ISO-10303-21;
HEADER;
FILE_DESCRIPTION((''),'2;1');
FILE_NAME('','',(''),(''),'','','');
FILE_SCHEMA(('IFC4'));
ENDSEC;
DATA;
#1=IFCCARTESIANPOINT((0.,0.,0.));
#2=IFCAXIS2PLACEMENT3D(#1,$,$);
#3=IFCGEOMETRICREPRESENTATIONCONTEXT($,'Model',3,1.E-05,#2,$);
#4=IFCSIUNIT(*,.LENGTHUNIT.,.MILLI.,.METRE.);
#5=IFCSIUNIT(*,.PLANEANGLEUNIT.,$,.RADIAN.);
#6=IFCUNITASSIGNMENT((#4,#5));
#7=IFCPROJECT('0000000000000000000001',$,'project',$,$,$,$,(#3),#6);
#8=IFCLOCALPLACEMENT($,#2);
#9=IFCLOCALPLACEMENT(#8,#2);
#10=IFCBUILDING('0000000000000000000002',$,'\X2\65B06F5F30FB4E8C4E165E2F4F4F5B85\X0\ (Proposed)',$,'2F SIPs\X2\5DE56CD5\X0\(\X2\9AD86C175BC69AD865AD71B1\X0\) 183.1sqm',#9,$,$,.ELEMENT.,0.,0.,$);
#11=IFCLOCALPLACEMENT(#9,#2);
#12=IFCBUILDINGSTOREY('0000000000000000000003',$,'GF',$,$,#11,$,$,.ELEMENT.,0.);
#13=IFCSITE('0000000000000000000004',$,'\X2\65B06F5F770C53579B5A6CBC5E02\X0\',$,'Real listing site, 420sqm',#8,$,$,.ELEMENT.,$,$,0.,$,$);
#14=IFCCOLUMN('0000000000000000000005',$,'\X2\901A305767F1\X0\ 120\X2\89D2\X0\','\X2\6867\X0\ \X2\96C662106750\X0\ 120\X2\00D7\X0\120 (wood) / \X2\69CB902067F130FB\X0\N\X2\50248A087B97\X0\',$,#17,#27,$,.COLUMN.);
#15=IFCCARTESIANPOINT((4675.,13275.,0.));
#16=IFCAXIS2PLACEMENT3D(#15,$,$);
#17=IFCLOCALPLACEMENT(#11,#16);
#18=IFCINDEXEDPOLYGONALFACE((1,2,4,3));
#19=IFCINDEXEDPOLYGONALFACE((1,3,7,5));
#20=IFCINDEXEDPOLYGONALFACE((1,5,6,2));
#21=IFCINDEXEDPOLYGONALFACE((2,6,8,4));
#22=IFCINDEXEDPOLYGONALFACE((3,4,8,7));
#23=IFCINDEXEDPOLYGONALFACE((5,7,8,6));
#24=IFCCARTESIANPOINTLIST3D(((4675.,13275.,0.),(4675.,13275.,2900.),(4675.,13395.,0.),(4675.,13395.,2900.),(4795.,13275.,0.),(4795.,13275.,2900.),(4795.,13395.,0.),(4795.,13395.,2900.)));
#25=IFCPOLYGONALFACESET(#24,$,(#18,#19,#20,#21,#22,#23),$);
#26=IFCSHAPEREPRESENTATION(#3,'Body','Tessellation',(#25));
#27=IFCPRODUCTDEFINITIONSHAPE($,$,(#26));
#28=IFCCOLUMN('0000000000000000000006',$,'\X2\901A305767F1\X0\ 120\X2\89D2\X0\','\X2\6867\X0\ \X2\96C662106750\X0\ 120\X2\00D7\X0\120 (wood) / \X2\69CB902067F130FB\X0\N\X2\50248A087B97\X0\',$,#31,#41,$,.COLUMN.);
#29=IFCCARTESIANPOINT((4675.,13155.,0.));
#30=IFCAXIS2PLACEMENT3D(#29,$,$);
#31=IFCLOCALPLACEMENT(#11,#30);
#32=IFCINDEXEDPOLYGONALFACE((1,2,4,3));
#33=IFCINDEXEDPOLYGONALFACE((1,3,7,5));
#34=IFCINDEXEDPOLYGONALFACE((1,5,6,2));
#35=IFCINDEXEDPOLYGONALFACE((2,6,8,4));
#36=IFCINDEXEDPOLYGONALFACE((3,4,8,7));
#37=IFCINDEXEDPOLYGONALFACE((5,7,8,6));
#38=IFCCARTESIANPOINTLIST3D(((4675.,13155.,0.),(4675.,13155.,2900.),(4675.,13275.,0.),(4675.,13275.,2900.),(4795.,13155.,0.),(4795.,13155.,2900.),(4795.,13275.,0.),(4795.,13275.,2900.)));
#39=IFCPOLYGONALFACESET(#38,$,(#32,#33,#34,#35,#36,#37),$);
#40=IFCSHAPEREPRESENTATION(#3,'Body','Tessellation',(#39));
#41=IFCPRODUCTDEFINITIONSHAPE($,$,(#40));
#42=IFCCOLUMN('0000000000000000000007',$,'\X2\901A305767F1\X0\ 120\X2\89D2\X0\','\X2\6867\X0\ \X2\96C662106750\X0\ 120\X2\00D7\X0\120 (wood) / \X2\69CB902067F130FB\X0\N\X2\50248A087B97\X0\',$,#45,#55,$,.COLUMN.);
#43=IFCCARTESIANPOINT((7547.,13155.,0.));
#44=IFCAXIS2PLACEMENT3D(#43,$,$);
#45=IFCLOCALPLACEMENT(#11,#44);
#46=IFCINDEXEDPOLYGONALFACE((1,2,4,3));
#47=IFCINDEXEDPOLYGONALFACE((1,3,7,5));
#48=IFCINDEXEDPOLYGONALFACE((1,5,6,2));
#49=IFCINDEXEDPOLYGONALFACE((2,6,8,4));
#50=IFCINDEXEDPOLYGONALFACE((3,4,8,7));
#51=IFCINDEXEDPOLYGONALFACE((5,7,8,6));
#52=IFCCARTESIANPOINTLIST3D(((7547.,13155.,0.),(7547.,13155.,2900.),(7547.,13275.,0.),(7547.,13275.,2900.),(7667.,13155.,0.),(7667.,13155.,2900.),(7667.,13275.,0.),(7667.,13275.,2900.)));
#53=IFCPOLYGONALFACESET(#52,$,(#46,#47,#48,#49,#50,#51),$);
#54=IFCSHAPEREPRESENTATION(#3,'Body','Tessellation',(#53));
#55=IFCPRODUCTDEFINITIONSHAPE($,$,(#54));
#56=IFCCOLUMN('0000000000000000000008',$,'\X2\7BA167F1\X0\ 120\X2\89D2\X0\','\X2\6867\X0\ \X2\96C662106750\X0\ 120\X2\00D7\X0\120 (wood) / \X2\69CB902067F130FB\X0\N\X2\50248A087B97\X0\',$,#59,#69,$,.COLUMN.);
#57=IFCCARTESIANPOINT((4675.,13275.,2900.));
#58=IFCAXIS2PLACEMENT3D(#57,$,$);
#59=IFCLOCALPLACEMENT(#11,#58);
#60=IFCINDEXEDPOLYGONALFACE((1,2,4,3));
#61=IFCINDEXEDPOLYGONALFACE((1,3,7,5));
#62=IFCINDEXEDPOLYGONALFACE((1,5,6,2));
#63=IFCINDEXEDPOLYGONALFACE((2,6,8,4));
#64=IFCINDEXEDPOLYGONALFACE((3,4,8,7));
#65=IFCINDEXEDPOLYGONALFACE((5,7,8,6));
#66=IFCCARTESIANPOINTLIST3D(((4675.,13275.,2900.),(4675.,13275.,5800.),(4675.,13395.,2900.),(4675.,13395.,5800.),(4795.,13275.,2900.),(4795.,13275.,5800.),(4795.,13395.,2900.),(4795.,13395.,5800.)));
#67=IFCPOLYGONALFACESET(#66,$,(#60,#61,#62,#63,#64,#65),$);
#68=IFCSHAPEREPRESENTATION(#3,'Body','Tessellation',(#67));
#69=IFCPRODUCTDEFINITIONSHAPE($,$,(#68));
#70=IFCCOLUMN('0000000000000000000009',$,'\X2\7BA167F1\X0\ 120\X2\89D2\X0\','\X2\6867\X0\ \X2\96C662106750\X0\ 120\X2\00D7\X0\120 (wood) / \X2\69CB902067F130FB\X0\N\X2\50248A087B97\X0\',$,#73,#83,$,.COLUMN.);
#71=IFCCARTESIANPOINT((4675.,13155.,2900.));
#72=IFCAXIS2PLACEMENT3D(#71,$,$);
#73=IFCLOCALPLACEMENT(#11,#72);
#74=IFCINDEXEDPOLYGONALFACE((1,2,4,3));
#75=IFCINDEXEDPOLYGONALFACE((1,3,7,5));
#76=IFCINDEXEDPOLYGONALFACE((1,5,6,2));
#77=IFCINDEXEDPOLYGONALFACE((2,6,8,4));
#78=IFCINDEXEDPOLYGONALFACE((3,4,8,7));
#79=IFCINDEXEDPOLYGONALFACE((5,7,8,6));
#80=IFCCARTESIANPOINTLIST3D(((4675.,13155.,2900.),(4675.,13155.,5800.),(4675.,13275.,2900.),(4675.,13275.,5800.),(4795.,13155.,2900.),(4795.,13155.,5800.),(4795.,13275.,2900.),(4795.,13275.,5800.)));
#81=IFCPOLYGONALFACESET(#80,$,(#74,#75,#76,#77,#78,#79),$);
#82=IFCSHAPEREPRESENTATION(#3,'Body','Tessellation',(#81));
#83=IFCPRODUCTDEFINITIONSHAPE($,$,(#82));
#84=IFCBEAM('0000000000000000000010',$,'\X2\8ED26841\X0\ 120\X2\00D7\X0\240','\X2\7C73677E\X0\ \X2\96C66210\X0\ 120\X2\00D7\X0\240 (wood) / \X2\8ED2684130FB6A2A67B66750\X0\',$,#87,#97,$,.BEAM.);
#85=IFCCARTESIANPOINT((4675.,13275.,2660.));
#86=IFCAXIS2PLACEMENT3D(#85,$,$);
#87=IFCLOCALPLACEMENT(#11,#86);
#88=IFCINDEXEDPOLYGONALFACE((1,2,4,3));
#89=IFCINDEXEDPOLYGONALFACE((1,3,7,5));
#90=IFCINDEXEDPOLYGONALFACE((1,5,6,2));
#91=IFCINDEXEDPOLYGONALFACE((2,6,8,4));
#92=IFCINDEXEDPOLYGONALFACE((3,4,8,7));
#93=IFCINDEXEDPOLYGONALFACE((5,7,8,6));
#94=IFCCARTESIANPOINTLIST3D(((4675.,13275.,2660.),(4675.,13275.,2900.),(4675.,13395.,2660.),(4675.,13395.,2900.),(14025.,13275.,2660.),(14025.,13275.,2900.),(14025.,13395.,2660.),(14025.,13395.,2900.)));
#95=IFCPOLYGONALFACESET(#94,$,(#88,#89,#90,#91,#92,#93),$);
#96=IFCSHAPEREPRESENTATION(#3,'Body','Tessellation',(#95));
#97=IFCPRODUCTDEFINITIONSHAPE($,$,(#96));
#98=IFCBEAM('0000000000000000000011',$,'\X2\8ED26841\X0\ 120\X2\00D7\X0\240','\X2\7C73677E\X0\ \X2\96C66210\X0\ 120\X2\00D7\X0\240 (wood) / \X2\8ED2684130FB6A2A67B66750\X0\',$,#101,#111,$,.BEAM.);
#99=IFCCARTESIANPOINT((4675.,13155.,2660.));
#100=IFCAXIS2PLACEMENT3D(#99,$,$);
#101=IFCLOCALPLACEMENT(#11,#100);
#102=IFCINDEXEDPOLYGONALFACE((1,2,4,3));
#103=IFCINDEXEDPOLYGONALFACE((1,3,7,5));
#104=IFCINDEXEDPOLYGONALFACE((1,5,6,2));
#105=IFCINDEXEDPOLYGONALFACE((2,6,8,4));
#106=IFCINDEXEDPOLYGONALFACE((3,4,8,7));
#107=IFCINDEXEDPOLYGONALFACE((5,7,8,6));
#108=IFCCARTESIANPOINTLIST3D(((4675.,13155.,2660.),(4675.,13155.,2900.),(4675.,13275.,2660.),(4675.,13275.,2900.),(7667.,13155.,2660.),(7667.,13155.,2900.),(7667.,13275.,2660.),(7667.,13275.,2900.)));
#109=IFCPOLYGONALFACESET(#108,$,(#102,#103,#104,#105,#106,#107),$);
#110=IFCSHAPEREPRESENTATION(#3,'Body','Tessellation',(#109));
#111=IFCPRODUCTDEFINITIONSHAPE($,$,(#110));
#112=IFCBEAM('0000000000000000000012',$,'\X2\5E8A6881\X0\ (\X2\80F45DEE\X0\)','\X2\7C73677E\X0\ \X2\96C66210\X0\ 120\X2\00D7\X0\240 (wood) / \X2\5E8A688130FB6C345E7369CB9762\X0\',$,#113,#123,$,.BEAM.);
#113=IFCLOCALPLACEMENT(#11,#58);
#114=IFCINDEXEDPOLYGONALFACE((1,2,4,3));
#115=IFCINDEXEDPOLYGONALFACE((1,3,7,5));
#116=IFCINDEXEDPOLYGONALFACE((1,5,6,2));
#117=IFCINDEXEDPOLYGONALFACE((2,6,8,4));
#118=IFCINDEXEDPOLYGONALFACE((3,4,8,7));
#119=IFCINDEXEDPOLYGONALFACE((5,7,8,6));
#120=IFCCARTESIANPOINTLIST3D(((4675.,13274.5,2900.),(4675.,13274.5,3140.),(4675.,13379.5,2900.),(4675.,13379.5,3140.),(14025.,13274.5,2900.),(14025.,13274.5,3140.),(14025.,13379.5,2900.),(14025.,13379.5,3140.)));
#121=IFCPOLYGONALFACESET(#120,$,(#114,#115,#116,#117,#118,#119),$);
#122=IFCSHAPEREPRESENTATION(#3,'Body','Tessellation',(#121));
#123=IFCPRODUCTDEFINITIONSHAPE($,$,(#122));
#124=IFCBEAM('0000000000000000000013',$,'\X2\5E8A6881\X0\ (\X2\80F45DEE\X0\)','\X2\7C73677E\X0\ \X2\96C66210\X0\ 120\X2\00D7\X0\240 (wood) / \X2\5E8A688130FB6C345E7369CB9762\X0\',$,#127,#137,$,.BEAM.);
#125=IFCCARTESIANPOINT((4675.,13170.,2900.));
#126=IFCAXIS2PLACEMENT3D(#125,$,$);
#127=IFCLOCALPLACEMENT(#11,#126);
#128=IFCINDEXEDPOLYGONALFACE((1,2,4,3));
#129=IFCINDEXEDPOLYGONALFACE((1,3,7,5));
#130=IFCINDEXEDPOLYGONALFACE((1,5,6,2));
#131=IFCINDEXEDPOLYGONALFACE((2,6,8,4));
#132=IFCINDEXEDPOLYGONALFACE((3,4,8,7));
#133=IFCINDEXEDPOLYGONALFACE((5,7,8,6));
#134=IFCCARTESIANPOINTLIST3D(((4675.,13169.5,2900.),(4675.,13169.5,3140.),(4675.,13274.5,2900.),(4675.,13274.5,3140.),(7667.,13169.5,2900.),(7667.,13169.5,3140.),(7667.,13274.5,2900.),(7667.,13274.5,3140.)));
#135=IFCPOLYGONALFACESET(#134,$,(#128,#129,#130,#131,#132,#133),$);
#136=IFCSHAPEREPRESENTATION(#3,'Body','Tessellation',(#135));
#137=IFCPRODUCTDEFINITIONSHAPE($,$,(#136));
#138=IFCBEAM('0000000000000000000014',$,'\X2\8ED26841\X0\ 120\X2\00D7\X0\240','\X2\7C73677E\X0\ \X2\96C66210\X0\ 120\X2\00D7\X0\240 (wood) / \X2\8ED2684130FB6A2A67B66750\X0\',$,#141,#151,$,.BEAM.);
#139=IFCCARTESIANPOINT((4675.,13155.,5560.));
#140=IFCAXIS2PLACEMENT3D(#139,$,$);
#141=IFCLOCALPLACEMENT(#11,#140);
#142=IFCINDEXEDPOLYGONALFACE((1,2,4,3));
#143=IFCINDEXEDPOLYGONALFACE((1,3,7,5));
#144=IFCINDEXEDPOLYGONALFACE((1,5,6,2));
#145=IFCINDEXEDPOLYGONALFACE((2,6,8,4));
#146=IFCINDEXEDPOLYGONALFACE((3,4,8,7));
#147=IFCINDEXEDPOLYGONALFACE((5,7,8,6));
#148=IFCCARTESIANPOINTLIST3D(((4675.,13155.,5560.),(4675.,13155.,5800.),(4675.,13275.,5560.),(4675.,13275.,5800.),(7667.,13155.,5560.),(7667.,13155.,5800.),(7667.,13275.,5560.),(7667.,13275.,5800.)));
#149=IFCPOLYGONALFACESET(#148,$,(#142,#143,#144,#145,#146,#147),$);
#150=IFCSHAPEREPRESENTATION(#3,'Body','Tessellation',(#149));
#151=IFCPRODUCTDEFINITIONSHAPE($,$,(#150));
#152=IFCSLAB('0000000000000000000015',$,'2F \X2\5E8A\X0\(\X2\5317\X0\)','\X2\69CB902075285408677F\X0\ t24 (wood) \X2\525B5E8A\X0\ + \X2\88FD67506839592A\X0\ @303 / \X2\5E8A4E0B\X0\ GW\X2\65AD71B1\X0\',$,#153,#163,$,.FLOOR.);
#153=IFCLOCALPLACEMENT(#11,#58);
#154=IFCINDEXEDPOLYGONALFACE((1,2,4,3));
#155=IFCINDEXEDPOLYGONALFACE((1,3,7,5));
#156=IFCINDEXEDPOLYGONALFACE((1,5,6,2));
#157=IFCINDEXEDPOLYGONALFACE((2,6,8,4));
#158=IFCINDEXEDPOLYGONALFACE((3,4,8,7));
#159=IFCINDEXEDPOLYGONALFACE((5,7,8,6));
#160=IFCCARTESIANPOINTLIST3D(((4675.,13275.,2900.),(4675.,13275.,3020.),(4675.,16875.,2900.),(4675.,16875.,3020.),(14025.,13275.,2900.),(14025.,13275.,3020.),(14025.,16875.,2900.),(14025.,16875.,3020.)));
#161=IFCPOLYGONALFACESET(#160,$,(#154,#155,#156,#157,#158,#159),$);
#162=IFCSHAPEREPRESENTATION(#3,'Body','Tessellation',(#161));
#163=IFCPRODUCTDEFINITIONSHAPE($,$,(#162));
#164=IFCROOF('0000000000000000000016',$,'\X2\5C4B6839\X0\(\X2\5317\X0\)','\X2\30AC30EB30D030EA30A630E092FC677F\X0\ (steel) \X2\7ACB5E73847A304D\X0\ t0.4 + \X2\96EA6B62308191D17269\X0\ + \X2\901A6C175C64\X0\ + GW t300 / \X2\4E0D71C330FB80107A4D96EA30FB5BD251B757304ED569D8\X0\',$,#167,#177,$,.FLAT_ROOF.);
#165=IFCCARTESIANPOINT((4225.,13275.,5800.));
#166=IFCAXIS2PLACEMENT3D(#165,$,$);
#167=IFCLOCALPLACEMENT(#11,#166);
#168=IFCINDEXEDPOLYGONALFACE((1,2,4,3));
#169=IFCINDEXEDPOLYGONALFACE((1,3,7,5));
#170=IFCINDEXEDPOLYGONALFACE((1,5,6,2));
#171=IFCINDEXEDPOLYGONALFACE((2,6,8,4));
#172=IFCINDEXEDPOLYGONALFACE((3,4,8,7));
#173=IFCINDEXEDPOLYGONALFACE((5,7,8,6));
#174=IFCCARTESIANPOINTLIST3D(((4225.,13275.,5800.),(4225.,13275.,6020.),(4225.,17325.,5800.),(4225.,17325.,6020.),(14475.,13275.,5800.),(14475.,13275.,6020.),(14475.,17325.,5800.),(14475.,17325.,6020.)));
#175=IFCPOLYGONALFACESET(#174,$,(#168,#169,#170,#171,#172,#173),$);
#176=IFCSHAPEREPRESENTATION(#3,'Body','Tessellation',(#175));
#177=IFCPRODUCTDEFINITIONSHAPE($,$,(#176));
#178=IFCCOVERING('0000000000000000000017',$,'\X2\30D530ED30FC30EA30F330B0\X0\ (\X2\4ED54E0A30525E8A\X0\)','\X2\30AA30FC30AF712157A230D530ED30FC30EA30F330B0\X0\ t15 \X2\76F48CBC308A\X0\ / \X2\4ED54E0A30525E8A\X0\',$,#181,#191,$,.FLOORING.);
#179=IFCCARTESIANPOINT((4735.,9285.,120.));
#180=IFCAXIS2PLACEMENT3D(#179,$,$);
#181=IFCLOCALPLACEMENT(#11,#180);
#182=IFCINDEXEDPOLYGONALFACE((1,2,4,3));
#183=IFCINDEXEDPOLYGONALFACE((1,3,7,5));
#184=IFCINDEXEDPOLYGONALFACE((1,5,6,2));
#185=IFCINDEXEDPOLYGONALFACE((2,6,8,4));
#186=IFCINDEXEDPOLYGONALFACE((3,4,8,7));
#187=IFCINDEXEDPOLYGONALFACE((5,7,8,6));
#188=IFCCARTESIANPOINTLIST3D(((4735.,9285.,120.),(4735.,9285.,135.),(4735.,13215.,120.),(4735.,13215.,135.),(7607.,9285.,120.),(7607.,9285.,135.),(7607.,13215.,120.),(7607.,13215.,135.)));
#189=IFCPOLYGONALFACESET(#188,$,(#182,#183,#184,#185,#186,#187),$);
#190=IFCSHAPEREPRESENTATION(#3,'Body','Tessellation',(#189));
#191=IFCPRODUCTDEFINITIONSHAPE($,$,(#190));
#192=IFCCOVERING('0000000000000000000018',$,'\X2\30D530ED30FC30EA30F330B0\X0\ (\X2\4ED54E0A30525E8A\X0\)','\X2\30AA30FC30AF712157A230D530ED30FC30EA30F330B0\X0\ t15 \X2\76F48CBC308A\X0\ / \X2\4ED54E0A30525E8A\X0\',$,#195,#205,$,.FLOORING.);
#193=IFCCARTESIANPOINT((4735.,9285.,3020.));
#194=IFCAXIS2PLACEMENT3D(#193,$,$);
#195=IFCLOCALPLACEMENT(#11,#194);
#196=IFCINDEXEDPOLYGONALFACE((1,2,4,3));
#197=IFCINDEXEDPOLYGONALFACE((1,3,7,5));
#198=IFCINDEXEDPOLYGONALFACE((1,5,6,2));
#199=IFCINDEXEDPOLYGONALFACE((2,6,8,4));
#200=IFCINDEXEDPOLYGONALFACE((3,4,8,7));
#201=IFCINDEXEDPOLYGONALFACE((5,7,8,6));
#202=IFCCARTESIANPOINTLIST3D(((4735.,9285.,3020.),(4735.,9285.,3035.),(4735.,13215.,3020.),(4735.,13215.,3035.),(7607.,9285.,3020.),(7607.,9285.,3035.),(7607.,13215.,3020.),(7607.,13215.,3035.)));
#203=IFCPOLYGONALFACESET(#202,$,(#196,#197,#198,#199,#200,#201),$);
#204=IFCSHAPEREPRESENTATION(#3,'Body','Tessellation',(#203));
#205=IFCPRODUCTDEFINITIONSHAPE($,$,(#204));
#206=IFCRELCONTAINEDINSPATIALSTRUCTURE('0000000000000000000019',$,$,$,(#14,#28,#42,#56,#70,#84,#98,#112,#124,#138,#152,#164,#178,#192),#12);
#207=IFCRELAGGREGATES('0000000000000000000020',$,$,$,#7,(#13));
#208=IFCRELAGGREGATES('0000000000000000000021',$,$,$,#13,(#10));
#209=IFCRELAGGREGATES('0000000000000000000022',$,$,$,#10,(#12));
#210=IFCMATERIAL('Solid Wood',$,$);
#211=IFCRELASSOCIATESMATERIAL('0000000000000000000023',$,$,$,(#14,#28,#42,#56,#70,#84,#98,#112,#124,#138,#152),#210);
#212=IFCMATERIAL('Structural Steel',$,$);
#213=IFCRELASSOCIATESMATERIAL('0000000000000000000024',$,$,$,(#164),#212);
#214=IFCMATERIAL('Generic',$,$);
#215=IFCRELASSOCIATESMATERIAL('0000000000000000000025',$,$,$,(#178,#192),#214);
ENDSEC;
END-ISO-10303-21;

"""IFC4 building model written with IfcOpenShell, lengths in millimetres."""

from ifc_helpers import new_model, si_unit, frame, frame_2d, origin, place, context, project, spatial, rectangle, extrude, material, element, save


model = new_model("IFC4")

# Units and contexts
model_context = context("Model", 3, precision=1e-05, world=origin())
ifc_project = project(units=[si_unit("LENGTHUNIT", "METRE", prefix="MILLI"), si_unit("PLANEANGLEUNIT", "RADIAN")], contexts=[model_context])

# Site, building, storey
site_placement = place(None, origin())
site = spatial("IfcSite", under=ifc_project, at=site_placement, Name="新潟県南魚沼市", ObjectType="Real listing site, 420sqm", CompositionType="ELEMENT", RefElevation=0.0)
building_placement = place(site_placement, origin())
building = spatial("IfcBuilding", under=site, at=building_placement, Name="新潟・二世帯住宅 (Proposed)", ObjectType="2F SIPs工法(高気密高断熱) 183.1sqm", CompositionType="ELEMENT", ElevationOfRefHeight=0.0, ElevationOfTerrain=0.0)
storey_placement = place(building_placement, origin())
storey = spatial("IfcBuildingStorey", under=building, at=storey_placement, Name="GF", CompositionType="ELEMENT", Elevation=0.0)

# Columns
ifc_material_1 = material(Name="Solid Wood")
column_1_placement = place(storey_placement, frame((4675.0, 13275.0, 0.0)))
element("IfcColumn", 1, at=column_1_placement, inside=storey, material=ifc_material_1, Name="通し柱 120角", Description="桧 集成材 120×120 (wood) / 構造柱・N値計算", PredefinedType="COLUMN", context=model_context, shape_type="SweptSolid", body=[
    extrude(rectangle(XDim=120.0, YDim=120.0, at=frame_2d((60.0, 60.0))), frame((4675.0, 13275.0, 0.0)), (0.0, 0.0, 1.0), 2900.0),
])
column_2_placement = place(storey_placement, frame((4675.0, 13155.0, 0.0)))
element("IfcColumn", 2, at=column_2_placement, inside=storey, material=ifc_material_1, Name="通し柱 120角", Description="桧 集成材 120×120 (wood) / 構造柱・N値計算", PredefinedType="COLUMN", context=model_context, shape_type="SweptSolid", body=[
    extrude(rectangle(XDim=120.0, YDim=120.0, at=frame_2d((60.0, 60.0))), frame((4675.0, 13155.0, 0.0)), (0.0, 0.0, 1.0), 2900.0),
])
column_3_placement = place(storey_placement, frame((7547.0, 13155.0, 0.0)))
element("IfcColumn", 3, at=column_3_placement, inside=storey, material=ifc_material_1, Name="通し柱 120角", Description="桧 集成材 120×120 (wood) / 構造柱・N値計算", PredefinedType="COLUMN", context=model_context, shape_type="SweptSolid", body=[
    extrude(rectangle(XDim=120.0, YDim=120.0, at=frame_2d((60.0, 60.0))), frame((7547.0, 13155.0, 0.0)), (0.0, 0.0, 1.0), 2900.0),
])
column_4_placement = place(storey_placement, frame((4675.0, 13275.0, 2900.0)))
element("IfcColumn", 4, at=column_4_placement, inside=storey, material=ifc_material_1, Name="管柱 120角", Description="桧 集成材 120×120 (wood) / 構造柱・N値計算", PredefinedType="COLUMN", context=model_context, shape_type="SweptSolid", body=[
    extrude(rectangle(XDim=120.0, YDim=120.0, at=frame_2d((60.0, 60.0))), frame((4675.0, 13275.0, 2900.0)), (0.0, 0.0, 1.0), 2900.0),
])
column_5_placement = place(storey_placement, frame((4675.0, 13155.0, 2900.0)))
element("IfcColumn", 5, at=column_5_placement, inside=storey, material=ifc_material_1, Name="管柱 120角", Description="桧 集成材 120×120 (wood) / 構造柱・N値計算", PredefinedType="COLUMN", context=model_context, shape_type="SweptSolid", body=[
    extrude(rectangle(XDim=120.0, YDim=120.0, at=frame_2d((60.0, 60.0))), frame((4675.0, 13155.0, 2900.0)), (0.0, 0.0, 1.0), 2900.0),
])

# Beams
beam_1_placement = place(storey_placement, frame((4675.0, 13275.0, 2660.0)))
element("IfcBeam", 6, at=beam_1_placement, inside=storey, material=ifc_material_1, Name="軒桁 120×240", Description="米松 集成 120×240 (wood) / 軒桁・横架材", PredefinedType="BEAM", context=model_context, shape_type="SweptSolid", body=[
    extrude(rectangle(XDim=9350.0, YDim=120.0, at=frame_2d((4675.0, 60.0))), frame((4675.0, 13275.0, 2660.0)), (0.0, 0.0, 1.0), 240.0),
])
beam_2_placement = place(storey_placement, frame((4675.0, 13155.0, 2660.0)))
element("IfcBeam", 7, at=beam_2_placement, inside=storey, material=ifc_material_1, Name="軒桁 120×240", Description="米松 集成 120×240 (wood) / 軒桁・横架材", PredefinedType="BEAM", context=model_context, shape_type="SweptSolid", body=[
    extrude(rectangle(XDim=2992.0, YDim=120.0, at=frame_2d((1496.0, 60.0))), frame((4675.0, 13155.0, 2660.0)), (0.0, 0.0, 1.0), 240.0),
])
beam_3_placement = place(storey_placement, frame((4675.0, 13275.0, 2900.0)))
element("IfcBeam", 8, at=beam_3_placement, inside=storey, material=ifc_material_1, Name="床梁 (胴差)", Description="米松 集成 120×240 (wood) / 床梁・水平構面", PredefinedType="BEAM", context=model_context, shape_type="SweptSolid", body=[
    extrude(rectangle(XDim=9350.0, YDim=105.0, at=frame_2d((4675.0, 52.0))), frame((4675.0, 13275.0, 2900.0)), (0.0, 0.0, 1.0), 240.0),
])
beam_4_placement = place(storey_placement, frame((4675.0, 13170.0, 2900.0)))
element("IfcBeam", 9, at=beam_4_placement, inside=storey, material=ifc_material_1, Name="床梁 (胴差)", Description="米松 集成 120×240 (wood) / 床梁・水平構面", PredefinedType="BEAM", context=model_context, shape_type="SweptSolid", body=[
    extrude(rectangle(XDim=2992.0, YDim=105.0, at=frame_2d((1496.0, 52.0))), frame((4675.0, 13170.0, 2900.0)), (0.0, 0.0, 1.0), 240.0),
])
beam_5_placement = place(storey_placement, frame((4675.0, 13155.0, 5560.0)))
element("IfcBeam", 10, at=beam_5_placement, inside=storey, material=ifc_material_1, Name="軒桁 120×240", Description="米松 集成 120×240 (wood) / 軒桁・横架材", PredefinedType="BEAM", context=model_context, shape_type="SweptSolid", body=[
    extrude(rectangle(XDim=2992.0, YDim=120.0, at=frame_2d((1496.0, 60.0))), frame((4675.0, 13155.0, 5560.0)), (0.0, 0.0, 1.0), 240.0),
])

# Slab
slab_1_placement = place(storey_placement, frame((4675.0, 13275.0, 2900.0)))
element("IfcSlab", 11, at=slab_1_placement, inside=storey, material=ifc_material_1, Name="2F 床(北)", Description="構造用合板 t24 (wood) 剛床 + 製材根太 @303 / 床下 GW断熱", PredefinedType="FLOOR", context=model_context, shape_type="SweptSolid", body=[
    extrude(rectangle(XDim=9350.0, YDim=3600.0, at=frame_2d((4675.0, 1800.0))), frame((4675.0, 13275.0, 2900.0)), (0.0, 0.0, 1.0), 120.0),
])

# Roof
ifc_material_2 = material(Name="Structural Steel")
for number, where, name in (
    (12, (4225.0, 13275.0, 5800.0), "屋根(北)"),
):
    element("IfcRoof", number, at=place(storey_placement, frame(where)), inside=storey, material=ifc_material_2, Name=name, Description="ガルバリウム鋼板 (steel) 立平葺き t0.4 + 雪止め金物 + 通気層 + GW t300 / 不燃・耐積雪・寒冷地仕様", PredefinedType="FLAT_ROOF", context=model_context, shape_type="SweptSolid", body=[
        extrude(rectangle(XDim=10250.0, YDim=4050.0, at=frame_2d((5125.0, 2025.0))), frame((4225.0, 13275.0, 5800.0)), (0.0, 0.0, 1.0), 220.0),
    ])

# Coverings
ifc_material_3 = material(Name="Generic")
covering_1_placement = place(storey_placement, frame((4735.0, 9285.0, 120.0)))
element("IfcCovering", 13, at=covering_1_placement, inside=storey, material=ifc_material_3, Name="フローリング (仕上げ床)", Description="オーク無垢フローリング t15 直貼り / 仕上げ床", PredefinedType="FLOORING", context=model_context, shape_type="SweptSolid", body=[
    extrude(rectangle(XDim=2872.0, YDim=3930.0, at=frame_2d((1436.0, 1965.0))), frame((4735.0, 9285.0, 120.0)), (0.0, 0.0, 1.0), 15.0),
])
covering_2_placement = place(storey_placement, frame((4735.0, 9285.0, 3020.0)))
element("IfcCovering", 14, at=covering_2_placement, inside=storey, material=ifc_material_3, Name="フローリング (仕上げ床)", Description="オーク無垢フローリング t15 直貼り / 仕上げ床", PredefinedType="FLOORING", context=model_context, shape_type="SweptSolid", body=[
    extrude(rectangle(XDim=2872.0, YDim=3930.0, at=frame_2d((1436.0, 1965.0))), frame((4735.0, 9285.0, 3020.0)), (0.0, 0.0, 1.0), 15.0),
])

save(model, "model.ifc")
